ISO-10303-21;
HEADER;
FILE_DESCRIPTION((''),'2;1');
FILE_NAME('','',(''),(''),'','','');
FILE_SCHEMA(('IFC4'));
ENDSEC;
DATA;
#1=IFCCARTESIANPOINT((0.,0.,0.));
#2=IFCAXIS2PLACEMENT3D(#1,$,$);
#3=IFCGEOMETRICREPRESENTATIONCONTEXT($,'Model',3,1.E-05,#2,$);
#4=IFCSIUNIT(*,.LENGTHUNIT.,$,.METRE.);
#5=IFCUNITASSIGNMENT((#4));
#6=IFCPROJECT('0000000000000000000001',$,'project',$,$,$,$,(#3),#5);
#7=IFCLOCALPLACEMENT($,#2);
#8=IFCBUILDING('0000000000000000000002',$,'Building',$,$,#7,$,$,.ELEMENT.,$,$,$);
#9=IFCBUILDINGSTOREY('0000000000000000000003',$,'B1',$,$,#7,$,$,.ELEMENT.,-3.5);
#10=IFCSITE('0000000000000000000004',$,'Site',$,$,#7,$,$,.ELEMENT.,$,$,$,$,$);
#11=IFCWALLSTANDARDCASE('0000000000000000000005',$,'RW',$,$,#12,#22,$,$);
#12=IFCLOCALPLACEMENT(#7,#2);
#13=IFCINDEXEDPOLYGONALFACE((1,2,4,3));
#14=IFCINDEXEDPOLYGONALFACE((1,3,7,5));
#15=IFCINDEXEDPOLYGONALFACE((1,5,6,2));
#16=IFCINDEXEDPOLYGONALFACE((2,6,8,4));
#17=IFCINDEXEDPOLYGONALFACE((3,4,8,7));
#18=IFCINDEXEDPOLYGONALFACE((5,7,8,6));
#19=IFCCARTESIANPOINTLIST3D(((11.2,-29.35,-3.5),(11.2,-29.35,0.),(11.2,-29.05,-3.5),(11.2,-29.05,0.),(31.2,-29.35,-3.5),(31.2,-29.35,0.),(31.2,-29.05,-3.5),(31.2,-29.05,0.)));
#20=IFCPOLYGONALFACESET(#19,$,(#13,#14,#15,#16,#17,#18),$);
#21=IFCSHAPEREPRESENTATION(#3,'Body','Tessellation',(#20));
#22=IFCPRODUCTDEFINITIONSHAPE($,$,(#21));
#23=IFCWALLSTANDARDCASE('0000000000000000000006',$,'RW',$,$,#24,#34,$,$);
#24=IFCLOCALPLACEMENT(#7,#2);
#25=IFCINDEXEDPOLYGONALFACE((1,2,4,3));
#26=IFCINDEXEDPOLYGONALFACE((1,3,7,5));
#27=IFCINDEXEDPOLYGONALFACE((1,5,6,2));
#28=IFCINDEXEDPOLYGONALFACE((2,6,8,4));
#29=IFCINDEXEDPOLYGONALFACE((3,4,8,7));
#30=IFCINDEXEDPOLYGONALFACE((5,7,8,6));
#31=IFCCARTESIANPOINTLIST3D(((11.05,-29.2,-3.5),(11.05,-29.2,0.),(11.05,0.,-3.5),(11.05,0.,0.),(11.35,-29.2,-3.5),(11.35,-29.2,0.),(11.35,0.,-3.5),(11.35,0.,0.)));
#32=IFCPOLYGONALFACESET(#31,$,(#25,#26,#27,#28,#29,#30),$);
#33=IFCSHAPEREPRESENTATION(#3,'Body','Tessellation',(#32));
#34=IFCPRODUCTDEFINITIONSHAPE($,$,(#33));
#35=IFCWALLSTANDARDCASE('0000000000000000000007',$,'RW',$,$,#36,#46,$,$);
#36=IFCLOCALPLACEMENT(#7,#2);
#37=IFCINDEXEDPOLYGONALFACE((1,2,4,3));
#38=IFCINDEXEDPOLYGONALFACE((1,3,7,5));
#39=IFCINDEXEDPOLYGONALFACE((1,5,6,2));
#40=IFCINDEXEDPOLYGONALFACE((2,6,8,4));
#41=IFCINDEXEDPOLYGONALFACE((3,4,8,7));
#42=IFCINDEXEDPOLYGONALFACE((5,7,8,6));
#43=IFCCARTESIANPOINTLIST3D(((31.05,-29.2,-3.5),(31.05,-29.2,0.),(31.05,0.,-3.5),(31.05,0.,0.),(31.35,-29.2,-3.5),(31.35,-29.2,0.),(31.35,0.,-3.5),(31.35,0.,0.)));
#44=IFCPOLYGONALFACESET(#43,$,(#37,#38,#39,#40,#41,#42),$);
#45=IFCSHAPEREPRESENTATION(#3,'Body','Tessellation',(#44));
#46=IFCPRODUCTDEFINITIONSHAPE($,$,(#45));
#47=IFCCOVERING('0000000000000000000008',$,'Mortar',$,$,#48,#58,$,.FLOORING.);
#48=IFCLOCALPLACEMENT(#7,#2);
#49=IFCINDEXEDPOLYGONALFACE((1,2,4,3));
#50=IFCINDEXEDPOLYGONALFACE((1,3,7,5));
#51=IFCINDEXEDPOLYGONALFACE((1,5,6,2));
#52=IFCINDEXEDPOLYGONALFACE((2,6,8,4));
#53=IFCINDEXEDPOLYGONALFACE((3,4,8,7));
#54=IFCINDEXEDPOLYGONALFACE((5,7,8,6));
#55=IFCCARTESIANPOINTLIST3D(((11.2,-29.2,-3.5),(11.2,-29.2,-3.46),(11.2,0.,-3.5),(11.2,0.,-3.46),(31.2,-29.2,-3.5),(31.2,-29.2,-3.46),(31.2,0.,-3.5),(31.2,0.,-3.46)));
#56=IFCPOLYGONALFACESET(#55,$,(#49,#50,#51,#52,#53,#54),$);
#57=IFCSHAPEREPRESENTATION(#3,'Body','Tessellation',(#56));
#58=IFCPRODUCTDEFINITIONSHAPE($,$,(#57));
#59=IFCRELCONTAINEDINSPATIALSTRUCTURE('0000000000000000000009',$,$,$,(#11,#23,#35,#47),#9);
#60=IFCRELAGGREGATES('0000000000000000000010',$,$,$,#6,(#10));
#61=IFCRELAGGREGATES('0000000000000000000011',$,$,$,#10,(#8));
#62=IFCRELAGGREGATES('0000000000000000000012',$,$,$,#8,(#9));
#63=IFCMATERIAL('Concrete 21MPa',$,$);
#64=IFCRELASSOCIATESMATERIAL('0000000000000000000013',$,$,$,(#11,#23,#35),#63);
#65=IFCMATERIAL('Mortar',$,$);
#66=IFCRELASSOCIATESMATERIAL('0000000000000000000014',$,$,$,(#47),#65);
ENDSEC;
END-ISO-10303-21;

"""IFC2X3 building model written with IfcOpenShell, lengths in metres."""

from ifc_helpers import new_model, si_unit, frame, origin, origin_2d, place, context, project, spatial, rectangle, extrude, material, element, save


model = new_model("IFC2X3")

# Units and contexts
model_context = context("Model", 3, precision=1e-05, world=origin())
ifc_project = project(units=[si_unit("LENGTHUNIT", "METRE")], contexts=[model_context])

# Site, building, storey
placement = place(None, origin())
site = spatial("IfcSite", under=ifc_project, at=placement, Name="Site", CompositionType="ELEMENT")
building = spatial("IfcBuilding", under=site, at=placement, Name="Building", CompositionType="ELEMENT")
storey = spatial("IfcBuildingStorey", under=building, at=placement, Name="B1", CompositionType="ELEMENT", Elevation=-3.5)

# Shared definitions
ifc_material_1 = material(Name="Concrete 21MPa")

# Walls
for number, where, name in (
    (1, (21.2, -29.2, -3.5), "RW"),
):
    element("IfcWallStandardCase", number, at=place(None, frame(where)), inside=storey, material=ifc_material_1, Name=name, context=model_context, shape_type="SweptSolid", body=[
        extrude(rectangle(XDim=20.0, YDim=0.3, at=origin_2d()), origin(), (0.0, 0.0, 1.0), 3.5),
    ])
for number, where, name in (
    (2, (11.2, -14.6, -3.5), "RW"),
    (3, (31.2, -14.6, -3.5), "RW"),
):
    element("IfcWallStandardCase", number, at=place(None, frame(where)), inside=storey, material=ifc_material_1, Name=name, context=model_context, shape_type="SweptSolid", body=[
        extrude(rectangle(XDim=0.3, YDim=29.2, at=origin_2d()), origin(), (0.0, 0.0, 1.0), 3.5),
    ])

# Covering
ifc_material_2 = material(Name="Mortar")
covering_placement = place(None, frame((21.2, -14.6, -3.5)))
element("IfcCovering", 4, at=covering_placement, inside=storey, material=ifc_material_2, Name="Mortar", PredefinedType="FLOORING", context=model_context, shape_type="SweptSolid", body=[
    extrude(rectangle(XDim=20.0, YDim=29.2, at=origin_2d()), origin(), (0.0, 0.0, 1.0), 0.04),
])

save(model, "model.ifc")
